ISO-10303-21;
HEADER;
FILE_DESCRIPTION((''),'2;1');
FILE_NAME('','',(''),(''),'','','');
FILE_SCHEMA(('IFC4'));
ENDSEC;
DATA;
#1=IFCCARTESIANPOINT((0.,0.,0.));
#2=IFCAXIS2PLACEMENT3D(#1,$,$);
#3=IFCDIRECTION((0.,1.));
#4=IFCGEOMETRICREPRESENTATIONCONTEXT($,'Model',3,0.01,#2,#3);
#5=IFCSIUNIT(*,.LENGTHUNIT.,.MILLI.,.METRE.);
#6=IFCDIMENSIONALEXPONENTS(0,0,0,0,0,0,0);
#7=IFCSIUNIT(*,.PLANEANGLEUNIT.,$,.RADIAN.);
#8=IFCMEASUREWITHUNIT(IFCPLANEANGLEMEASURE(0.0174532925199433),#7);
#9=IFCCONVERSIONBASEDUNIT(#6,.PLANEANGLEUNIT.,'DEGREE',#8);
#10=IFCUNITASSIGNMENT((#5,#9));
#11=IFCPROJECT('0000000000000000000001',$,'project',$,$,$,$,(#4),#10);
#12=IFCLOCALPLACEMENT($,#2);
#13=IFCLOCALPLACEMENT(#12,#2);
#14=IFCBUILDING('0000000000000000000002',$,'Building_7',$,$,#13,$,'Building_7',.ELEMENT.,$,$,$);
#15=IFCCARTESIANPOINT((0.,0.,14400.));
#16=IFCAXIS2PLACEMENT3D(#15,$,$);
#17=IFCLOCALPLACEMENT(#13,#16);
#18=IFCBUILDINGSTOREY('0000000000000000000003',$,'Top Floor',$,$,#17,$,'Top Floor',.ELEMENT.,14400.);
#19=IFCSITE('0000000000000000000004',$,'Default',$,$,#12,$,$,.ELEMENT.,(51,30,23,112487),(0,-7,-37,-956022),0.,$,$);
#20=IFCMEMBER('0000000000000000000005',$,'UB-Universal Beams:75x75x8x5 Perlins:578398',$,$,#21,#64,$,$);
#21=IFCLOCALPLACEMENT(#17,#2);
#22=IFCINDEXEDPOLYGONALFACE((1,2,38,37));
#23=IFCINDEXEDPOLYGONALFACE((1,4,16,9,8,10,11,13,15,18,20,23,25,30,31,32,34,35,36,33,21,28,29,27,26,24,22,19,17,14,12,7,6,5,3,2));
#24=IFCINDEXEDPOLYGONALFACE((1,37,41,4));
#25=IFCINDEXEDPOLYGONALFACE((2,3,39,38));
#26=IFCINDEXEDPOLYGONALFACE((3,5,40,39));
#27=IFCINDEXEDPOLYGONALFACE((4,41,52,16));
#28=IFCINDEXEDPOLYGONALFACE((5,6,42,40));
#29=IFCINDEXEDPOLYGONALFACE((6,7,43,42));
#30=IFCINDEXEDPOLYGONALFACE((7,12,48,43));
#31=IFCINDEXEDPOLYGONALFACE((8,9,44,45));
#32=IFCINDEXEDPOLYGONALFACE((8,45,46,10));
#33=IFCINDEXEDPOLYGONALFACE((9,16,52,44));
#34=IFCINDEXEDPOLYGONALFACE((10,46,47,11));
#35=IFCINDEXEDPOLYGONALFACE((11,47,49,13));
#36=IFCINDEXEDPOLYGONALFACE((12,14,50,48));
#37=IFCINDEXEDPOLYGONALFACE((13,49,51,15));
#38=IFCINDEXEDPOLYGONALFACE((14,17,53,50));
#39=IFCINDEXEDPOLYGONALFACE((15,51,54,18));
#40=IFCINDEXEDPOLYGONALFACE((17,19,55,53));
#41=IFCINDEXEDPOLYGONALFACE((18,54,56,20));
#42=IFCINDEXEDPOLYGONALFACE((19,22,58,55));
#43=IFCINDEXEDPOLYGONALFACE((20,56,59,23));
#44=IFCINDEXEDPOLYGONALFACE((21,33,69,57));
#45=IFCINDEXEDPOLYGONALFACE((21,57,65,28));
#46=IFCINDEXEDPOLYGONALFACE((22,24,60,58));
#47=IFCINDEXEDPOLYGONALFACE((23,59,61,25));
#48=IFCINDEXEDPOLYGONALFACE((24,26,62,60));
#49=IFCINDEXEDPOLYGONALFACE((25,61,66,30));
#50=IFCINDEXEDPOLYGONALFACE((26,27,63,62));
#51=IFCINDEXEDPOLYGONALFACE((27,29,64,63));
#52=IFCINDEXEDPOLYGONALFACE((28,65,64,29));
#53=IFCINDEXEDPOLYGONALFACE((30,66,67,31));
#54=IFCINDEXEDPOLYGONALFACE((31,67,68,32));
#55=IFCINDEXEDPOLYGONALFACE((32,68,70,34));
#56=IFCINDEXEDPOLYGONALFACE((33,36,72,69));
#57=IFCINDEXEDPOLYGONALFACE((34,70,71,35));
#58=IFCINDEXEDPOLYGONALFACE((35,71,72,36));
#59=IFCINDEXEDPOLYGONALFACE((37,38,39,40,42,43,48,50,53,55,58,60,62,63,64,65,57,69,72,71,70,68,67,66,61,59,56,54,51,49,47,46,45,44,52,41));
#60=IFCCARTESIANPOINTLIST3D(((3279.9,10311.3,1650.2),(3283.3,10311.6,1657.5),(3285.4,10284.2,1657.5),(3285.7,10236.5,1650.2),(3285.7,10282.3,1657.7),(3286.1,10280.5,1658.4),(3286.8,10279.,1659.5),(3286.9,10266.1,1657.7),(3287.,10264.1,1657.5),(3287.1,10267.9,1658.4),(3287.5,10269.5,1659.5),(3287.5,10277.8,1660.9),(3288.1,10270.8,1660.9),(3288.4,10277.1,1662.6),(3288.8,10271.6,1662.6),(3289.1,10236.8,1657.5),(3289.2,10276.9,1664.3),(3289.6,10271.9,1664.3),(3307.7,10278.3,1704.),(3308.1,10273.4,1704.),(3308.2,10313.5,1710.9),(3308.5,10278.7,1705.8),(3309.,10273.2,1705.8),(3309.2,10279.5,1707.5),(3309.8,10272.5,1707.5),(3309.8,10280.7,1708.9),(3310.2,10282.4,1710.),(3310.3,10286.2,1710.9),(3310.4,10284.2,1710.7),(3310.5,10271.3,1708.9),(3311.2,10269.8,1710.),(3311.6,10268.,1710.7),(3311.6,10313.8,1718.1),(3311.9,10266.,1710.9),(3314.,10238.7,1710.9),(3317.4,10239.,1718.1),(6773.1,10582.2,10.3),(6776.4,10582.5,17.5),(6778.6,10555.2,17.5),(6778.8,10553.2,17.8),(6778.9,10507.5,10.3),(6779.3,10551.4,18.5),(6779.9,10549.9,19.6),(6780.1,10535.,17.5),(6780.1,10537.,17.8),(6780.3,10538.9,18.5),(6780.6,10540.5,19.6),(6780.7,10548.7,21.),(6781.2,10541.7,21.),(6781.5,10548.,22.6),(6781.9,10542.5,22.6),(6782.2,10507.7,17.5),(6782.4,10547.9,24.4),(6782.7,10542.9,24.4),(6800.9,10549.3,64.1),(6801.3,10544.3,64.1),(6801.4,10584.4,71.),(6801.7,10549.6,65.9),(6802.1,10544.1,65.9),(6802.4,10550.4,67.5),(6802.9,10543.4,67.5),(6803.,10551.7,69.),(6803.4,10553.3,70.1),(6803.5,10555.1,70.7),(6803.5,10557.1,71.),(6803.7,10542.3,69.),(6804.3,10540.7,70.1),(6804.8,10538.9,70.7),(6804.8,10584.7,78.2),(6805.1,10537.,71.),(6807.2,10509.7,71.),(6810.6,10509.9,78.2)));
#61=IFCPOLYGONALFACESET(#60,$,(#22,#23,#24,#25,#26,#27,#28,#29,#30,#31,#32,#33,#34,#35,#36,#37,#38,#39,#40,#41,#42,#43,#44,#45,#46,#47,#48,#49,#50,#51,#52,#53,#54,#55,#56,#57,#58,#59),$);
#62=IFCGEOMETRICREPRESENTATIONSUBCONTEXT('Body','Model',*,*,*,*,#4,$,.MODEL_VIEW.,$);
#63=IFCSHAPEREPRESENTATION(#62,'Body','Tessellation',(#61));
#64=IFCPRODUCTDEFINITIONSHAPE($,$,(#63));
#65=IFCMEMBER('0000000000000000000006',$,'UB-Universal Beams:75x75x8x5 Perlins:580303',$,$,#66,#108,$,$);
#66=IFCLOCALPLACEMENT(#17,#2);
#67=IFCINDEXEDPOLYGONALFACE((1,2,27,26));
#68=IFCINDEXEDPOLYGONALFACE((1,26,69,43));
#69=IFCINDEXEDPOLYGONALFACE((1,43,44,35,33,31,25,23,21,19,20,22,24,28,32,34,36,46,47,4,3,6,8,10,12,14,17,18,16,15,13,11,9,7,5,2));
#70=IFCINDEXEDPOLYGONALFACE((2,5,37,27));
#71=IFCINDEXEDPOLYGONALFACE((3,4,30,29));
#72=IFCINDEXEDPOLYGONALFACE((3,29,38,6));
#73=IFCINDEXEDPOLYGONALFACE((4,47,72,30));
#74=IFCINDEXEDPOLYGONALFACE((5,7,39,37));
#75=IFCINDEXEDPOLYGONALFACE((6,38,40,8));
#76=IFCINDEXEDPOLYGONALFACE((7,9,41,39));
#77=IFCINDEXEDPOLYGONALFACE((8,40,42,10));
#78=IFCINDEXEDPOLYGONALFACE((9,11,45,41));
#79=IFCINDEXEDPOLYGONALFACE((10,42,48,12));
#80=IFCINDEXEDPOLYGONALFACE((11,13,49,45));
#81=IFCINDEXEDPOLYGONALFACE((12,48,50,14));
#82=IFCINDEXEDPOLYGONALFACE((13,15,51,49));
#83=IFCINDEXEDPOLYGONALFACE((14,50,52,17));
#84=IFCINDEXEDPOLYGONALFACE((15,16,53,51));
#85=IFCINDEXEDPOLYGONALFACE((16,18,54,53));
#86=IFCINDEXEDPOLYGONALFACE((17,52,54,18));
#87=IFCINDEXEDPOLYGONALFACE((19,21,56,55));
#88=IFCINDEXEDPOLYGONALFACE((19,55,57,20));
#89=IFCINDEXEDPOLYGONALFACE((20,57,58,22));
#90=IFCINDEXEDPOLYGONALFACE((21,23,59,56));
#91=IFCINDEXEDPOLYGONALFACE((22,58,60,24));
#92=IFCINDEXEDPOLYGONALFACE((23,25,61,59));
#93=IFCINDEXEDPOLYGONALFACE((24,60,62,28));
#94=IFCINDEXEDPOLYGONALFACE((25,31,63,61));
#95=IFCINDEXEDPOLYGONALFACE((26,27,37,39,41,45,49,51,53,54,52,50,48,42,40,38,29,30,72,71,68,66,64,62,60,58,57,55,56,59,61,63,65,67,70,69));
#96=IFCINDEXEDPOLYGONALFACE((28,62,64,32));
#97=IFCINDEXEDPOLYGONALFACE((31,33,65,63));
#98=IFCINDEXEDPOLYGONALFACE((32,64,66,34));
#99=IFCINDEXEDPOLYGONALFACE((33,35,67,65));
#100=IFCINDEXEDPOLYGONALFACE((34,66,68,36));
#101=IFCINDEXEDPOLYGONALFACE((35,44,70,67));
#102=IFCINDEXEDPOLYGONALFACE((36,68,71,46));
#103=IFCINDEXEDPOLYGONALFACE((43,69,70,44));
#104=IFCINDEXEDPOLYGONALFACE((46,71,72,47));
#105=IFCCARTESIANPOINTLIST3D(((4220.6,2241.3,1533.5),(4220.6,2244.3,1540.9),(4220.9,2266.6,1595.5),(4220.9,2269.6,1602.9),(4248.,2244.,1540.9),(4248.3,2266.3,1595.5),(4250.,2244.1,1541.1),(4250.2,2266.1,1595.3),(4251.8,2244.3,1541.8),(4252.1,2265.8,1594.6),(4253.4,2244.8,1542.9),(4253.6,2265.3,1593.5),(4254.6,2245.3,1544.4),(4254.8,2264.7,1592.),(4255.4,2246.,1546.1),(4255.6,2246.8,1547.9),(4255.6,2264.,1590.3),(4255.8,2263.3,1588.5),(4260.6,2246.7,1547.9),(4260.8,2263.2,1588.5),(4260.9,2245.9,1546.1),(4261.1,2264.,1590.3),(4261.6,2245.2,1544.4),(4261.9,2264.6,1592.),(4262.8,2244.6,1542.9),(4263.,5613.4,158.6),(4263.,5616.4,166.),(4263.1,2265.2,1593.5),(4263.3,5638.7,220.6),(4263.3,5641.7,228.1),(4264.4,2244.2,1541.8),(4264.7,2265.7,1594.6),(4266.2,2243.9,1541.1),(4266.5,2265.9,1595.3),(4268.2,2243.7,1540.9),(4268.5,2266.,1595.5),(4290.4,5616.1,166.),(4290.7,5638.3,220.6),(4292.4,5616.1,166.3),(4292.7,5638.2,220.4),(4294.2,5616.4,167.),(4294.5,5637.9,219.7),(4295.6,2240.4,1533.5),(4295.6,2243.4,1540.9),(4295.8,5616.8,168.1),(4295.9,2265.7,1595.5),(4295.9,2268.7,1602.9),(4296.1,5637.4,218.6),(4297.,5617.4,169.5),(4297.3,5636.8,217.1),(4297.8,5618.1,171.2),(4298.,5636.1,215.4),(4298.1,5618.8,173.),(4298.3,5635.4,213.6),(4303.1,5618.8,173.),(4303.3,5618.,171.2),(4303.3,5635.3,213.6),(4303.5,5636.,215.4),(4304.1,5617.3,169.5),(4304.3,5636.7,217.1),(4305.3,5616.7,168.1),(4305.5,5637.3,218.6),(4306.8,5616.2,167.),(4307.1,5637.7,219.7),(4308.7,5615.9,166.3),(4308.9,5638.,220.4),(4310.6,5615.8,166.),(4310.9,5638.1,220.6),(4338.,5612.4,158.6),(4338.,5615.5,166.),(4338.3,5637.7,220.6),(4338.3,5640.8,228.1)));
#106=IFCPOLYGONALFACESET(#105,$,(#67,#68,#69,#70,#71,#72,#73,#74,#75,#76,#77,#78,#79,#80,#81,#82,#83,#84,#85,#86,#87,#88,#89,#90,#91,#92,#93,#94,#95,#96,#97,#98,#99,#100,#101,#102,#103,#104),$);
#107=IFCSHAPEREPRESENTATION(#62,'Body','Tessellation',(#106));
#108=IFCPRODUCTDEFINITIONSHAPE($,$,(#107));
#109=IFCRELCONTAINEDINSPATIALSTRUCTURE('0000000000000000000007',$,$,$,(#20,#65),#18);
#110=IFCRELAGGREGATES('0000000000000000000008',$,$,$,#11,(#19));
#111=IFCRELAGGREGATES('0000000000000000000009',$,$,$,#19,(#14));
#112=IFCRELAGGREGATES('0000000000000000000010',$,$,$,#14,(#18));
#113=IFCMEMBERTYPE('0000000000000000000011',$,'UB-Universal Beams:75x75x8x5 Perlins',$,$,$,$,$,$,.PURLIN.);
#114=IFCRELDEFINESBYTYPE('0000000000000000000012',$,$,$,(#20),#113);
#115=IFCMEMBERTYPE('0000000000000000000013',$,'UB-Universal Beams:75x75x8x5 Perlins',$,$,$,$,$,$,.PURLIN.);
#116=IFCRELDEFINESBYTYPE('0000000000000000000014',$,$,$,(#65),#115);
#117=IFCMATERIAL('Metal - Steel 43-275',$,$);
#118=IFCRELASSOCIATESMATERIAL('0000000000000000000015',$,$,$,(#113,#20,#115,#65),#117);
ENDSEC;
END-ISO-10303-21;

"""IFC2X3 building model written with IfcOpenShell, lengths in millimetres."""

from ifc_helpers import new_model, entity, si_unit, converted_unit, direction, frame, frame_2d, origin, place, context, subcontext, project, spatial, polyline, circle_curve, parameter, trimmed, segment, composite_curve, outline, extrude, source, transform, mapped, material, type_object, type_shapes, element, save


model = new_model("IFC2X3")

# Units and contexts
model_context = context("Model", 3, precision=0.01, world=origin(), true_north=direction((0.0, 1.0)))
body_context = subcontext(model_context, "Body", "Model", "MODEL_VIEW")
ifc_project = project(units=[si_unit("LENGTHUNIT", "METRE", prefix="MILLI"), converted_unit("PLANEANGLEUNIT", "DEGREE", entity("IfcPlaneAngleMeasure", 0.0174532925199433), si_unit("PLANEANGLEUNIT", "RADIAN"), dimensions=[0, 0, 0, 0, 0, 0, 0])], contexts=[model_context])

# Site, building, storey
site_placement = place(None, origin())
site = spatial("IfcSite", under=ifc_project, at=site_placement, Name="Default", CompositionType="ELEMENT", RefLatitude=(51, 30, 23, 112487), RefLongitude=(0, -7, -37, -956022), RefElevation=0.0)
building_placement = place(site_placement, origin())
building = spatial("IfcBuilding", under=site, at=building_placement, Name="Building_7", LongName="Building_7", CompositionType="ELEMENT")
storey_placement = place(building_placement, frame((0.0, 0.0, 14400.0)))
storey = spatial("IfcBuildingStorey", under=building, at=storey_placement, Name="Top Floor", LongName="Top Floor", CompositionType="ELEMENT", Elevation=14400.0)

# Shared definitions
ifc_material = material(Name="Metal - Steel 43-275")

# Members
member_type_1 = type_object("IfcMemberType", Name="UB-Universal Beams:75x75x8x5 Perlins", PredefinedType="PURLIN", material=ifc_material)
shared_shape_1 = source(origin(), body_context, "Body", "SweptSolid", [
    extrude(outline(composite_curve([segment(polyline([(-37.5, -29.5), (-37.5, -37.5)]), True, "CONTINUOUS"), segment(polyline([(-37.5, -37.5), (37.5, -37.5)]), True, "CONTINUOUS"), segment(polyline([(37.5, -37.5), (37.5, -29.5)]), True, "CONTINUOUS"), segment(polyline([(37.5, -29.5), (10.1, -29.5)]), True, "CONTINUOUS"), segment(trimmed(circle_curve(frame_2d((10.1, -21.9), x_axis=(1.0, 0.0)), 7.6), [parameter(180.0)], [parameter(270.0)], True, "PARAMETER"), False, "CONTINUOUS"), segment(polyline([(2.5, -21.9), (2.5, 21.9)]), True, "CONTINUOUS"), segment(trimmed(circle_curve(frame_2d((10.1, 21.9), x_axis=(1.0, 0.0)), 7.6), [parameter(90.0)], [parameter(180.0)], True, "PARAMETER"), False, "CONTINUOUS"), segment(polyline([(10.1, 29.5), (37.5, 29.5)]), True, "CONTINUOUS"), segment(polyline([(37.5, 29.5), (37.5, 37.5)]), True, "CONTINUOUS"), segment(polyline([(37.5, 37.5), (-37.5, 37.5)]), True, "CONTINUOUS"), segment(polyline([(-37.5, 37.5), (-37.5, 29.5)]), True, "CONTINUOUS"), segment(polyline([(-37.5, 29.5), (-10.1, 29.5)]), True, "CONTINUOUS"), segment(trimmed(circle_curve(frame_2d((-10.1, 21.9), x_axis=(1.0, 0.0)), 7.6), [parameter(360.0)], [parameter(90.0)], True, "PARAMETER"), False, "CONTINUOUS"), segment(polyline([(-2.5, 21.9), (-2.5, -21.9)]), True, "CONTINUOUS"), segment(trimmed(circle_curve(frame_2d((-10.1, -21.9), x_axis=(1.0, 0.0)), 7.6), [parameter(270.0)], [parameter(360.0)], True, "PARAMETER"), False, "CONTINUOUS"), segment(polyline([(-10.1, -29.5), (-37.5, -29.5)]), True, "CONTINUOUS")], self_intersect=False)), frame((-2014.0, 0.0, 0.0), z_axis=(-1.0, 0.0, 0.0), x_axis=(0.0, -1.0, 0.0)), (0.0, 0.0, -1.0), 3868.5),
])
type_shapes(member_type_1, [shared_shape_1])
member_1_placement = place(storey_placement, frame((4973.2, 10405.0, 898.0), z_axis=(0.422654, 0.032783, 0.905698), x_axis=(-0.902986, -0.07004, 0.423924)))
element("IfcMember", 1, at=member_1_placement, inside=storey, type_object=member_type_1, material=ifc_material, Name="UB-Universal Beams:75x75x8x5 Perlins:578398", context=body_context, shape_type="MappedRepresentation", body=[
    mapped(shared_shape_1, transform((0.0, 0.0, 0.0), scale=1.0)),
])
member_type_2 = type_object("IfcMemberType", Name="UB-Universal Beams:75x75x8x5 Perlins", PredefinedType="PURLIN", material=ifc_material)
shared_shape_2 = source(origin(), body_context, "Body", "SweptSolid", [
    extrude(outline(composite_curve([segment(polyline([(29.5, -37.5), (37.5, -37.5)]), True, "CONTINUOUS"), segment(polyline([(37.5, -37.5), (37.5, 37.5)]), True, "CONTINUOUS"), segment(polyline([(37.5, 37.5), (29.5, 37.5)]), True, "CONTINUOUS"), segment(polyline([(29.5, 37.5), (29.5, 10.1)]), True, "CONTINUOUS"), segment(trimmed(circle_curve(frame_2d((21.9, 10.1), x_axis=(0.0, 1.0)), 7.6), [parameter(180.0)], [parameter(270.0)], True, "PARAMETER"), False, "CONTINUOUS"), segment(polyline([(21.9, 2.5), (-21.9, 2.5)]), True, "CONTINUOUS"), segment(trimmed(circle_curve(frame_2d((-21.9, 10.1), x_axis=(0.0, 1.0)), 7.6), [parameter(90.0)], [parameter(180.0)], True, "PARAMETER"), False, "CONTINUOUS"), segment(polyline([(-29.5, 10.1), (-29.5, 37.5)]), True, "CONTINUOUS"), segment(polyline([(-29.5, 37.5), (-37.5, 37.5)]), True, "CONTINUOUS"), segment(polyline([(-37.5, 37.5), (-37.5, -37.5)]), True, "CONTINUOUS"), segment(polyline([(-37.5, -37.5), (-29.5, -37.5)]), True, "CONTINUOUS"), segment(polyline([(-29.5, -37.5), (-29.5, -10.1)]), True, "CONTINUOUS"), segment(trimmed(circle_curve(frame_2d((-21.9, -10.1), x_axis=(0.0, 1.0)), 7.6), [parameter(360.0)], [parameter(90.0)], True, "PARAMETER"), False, "CONTINUOUS"), segment(polyline([(-21.9, -2.5), (21.9, -2.5)]), True, "CONTINUOUS"), segment(trimmed(circle_curve(frame_2d((21.9, -10.1), x_axis=(0.0, 1.0)), 7.6), [parameter(270.0)], [parameter(360.0)], True, "PARAMETER"), False, "CONTINUOUS"), segment(polyline([(29.5, -10.1), (29.5, -37.5)]), True, "CONTINUOUS")], self_intersect=False)), frame((-1895.3, 0.0, 0.0), z_axis=(1.0, 0.0, 0.0), x_axis=(0.0, 0.0, -1.0)), (0.0, 0.0, 1.0), 3641.8),
])
type_shapes(member_type_2, [shared_shape_2])
member_2_placement = place(storey_placement, frame((4278.6, 3872.2, 908.8), z_axis=(0.004749, 0.37749, 0.926001), x_axis=(-0.01165, -0.925928, 0.37752)))
element("IfcMember", 2, at=member_2_placement, inside=storey, type_object=member_type_2, material=ifc_material, Name="UB-Universal Beams:75x75x8x5 Perlins:580303", context=body_context, shape_type="MappedRepresentation", body=[
    mapped(shared_shape_2, transform((0.0, 0.0, 0.0), scale=1.0)),
])

save(model, "model.ifc")
